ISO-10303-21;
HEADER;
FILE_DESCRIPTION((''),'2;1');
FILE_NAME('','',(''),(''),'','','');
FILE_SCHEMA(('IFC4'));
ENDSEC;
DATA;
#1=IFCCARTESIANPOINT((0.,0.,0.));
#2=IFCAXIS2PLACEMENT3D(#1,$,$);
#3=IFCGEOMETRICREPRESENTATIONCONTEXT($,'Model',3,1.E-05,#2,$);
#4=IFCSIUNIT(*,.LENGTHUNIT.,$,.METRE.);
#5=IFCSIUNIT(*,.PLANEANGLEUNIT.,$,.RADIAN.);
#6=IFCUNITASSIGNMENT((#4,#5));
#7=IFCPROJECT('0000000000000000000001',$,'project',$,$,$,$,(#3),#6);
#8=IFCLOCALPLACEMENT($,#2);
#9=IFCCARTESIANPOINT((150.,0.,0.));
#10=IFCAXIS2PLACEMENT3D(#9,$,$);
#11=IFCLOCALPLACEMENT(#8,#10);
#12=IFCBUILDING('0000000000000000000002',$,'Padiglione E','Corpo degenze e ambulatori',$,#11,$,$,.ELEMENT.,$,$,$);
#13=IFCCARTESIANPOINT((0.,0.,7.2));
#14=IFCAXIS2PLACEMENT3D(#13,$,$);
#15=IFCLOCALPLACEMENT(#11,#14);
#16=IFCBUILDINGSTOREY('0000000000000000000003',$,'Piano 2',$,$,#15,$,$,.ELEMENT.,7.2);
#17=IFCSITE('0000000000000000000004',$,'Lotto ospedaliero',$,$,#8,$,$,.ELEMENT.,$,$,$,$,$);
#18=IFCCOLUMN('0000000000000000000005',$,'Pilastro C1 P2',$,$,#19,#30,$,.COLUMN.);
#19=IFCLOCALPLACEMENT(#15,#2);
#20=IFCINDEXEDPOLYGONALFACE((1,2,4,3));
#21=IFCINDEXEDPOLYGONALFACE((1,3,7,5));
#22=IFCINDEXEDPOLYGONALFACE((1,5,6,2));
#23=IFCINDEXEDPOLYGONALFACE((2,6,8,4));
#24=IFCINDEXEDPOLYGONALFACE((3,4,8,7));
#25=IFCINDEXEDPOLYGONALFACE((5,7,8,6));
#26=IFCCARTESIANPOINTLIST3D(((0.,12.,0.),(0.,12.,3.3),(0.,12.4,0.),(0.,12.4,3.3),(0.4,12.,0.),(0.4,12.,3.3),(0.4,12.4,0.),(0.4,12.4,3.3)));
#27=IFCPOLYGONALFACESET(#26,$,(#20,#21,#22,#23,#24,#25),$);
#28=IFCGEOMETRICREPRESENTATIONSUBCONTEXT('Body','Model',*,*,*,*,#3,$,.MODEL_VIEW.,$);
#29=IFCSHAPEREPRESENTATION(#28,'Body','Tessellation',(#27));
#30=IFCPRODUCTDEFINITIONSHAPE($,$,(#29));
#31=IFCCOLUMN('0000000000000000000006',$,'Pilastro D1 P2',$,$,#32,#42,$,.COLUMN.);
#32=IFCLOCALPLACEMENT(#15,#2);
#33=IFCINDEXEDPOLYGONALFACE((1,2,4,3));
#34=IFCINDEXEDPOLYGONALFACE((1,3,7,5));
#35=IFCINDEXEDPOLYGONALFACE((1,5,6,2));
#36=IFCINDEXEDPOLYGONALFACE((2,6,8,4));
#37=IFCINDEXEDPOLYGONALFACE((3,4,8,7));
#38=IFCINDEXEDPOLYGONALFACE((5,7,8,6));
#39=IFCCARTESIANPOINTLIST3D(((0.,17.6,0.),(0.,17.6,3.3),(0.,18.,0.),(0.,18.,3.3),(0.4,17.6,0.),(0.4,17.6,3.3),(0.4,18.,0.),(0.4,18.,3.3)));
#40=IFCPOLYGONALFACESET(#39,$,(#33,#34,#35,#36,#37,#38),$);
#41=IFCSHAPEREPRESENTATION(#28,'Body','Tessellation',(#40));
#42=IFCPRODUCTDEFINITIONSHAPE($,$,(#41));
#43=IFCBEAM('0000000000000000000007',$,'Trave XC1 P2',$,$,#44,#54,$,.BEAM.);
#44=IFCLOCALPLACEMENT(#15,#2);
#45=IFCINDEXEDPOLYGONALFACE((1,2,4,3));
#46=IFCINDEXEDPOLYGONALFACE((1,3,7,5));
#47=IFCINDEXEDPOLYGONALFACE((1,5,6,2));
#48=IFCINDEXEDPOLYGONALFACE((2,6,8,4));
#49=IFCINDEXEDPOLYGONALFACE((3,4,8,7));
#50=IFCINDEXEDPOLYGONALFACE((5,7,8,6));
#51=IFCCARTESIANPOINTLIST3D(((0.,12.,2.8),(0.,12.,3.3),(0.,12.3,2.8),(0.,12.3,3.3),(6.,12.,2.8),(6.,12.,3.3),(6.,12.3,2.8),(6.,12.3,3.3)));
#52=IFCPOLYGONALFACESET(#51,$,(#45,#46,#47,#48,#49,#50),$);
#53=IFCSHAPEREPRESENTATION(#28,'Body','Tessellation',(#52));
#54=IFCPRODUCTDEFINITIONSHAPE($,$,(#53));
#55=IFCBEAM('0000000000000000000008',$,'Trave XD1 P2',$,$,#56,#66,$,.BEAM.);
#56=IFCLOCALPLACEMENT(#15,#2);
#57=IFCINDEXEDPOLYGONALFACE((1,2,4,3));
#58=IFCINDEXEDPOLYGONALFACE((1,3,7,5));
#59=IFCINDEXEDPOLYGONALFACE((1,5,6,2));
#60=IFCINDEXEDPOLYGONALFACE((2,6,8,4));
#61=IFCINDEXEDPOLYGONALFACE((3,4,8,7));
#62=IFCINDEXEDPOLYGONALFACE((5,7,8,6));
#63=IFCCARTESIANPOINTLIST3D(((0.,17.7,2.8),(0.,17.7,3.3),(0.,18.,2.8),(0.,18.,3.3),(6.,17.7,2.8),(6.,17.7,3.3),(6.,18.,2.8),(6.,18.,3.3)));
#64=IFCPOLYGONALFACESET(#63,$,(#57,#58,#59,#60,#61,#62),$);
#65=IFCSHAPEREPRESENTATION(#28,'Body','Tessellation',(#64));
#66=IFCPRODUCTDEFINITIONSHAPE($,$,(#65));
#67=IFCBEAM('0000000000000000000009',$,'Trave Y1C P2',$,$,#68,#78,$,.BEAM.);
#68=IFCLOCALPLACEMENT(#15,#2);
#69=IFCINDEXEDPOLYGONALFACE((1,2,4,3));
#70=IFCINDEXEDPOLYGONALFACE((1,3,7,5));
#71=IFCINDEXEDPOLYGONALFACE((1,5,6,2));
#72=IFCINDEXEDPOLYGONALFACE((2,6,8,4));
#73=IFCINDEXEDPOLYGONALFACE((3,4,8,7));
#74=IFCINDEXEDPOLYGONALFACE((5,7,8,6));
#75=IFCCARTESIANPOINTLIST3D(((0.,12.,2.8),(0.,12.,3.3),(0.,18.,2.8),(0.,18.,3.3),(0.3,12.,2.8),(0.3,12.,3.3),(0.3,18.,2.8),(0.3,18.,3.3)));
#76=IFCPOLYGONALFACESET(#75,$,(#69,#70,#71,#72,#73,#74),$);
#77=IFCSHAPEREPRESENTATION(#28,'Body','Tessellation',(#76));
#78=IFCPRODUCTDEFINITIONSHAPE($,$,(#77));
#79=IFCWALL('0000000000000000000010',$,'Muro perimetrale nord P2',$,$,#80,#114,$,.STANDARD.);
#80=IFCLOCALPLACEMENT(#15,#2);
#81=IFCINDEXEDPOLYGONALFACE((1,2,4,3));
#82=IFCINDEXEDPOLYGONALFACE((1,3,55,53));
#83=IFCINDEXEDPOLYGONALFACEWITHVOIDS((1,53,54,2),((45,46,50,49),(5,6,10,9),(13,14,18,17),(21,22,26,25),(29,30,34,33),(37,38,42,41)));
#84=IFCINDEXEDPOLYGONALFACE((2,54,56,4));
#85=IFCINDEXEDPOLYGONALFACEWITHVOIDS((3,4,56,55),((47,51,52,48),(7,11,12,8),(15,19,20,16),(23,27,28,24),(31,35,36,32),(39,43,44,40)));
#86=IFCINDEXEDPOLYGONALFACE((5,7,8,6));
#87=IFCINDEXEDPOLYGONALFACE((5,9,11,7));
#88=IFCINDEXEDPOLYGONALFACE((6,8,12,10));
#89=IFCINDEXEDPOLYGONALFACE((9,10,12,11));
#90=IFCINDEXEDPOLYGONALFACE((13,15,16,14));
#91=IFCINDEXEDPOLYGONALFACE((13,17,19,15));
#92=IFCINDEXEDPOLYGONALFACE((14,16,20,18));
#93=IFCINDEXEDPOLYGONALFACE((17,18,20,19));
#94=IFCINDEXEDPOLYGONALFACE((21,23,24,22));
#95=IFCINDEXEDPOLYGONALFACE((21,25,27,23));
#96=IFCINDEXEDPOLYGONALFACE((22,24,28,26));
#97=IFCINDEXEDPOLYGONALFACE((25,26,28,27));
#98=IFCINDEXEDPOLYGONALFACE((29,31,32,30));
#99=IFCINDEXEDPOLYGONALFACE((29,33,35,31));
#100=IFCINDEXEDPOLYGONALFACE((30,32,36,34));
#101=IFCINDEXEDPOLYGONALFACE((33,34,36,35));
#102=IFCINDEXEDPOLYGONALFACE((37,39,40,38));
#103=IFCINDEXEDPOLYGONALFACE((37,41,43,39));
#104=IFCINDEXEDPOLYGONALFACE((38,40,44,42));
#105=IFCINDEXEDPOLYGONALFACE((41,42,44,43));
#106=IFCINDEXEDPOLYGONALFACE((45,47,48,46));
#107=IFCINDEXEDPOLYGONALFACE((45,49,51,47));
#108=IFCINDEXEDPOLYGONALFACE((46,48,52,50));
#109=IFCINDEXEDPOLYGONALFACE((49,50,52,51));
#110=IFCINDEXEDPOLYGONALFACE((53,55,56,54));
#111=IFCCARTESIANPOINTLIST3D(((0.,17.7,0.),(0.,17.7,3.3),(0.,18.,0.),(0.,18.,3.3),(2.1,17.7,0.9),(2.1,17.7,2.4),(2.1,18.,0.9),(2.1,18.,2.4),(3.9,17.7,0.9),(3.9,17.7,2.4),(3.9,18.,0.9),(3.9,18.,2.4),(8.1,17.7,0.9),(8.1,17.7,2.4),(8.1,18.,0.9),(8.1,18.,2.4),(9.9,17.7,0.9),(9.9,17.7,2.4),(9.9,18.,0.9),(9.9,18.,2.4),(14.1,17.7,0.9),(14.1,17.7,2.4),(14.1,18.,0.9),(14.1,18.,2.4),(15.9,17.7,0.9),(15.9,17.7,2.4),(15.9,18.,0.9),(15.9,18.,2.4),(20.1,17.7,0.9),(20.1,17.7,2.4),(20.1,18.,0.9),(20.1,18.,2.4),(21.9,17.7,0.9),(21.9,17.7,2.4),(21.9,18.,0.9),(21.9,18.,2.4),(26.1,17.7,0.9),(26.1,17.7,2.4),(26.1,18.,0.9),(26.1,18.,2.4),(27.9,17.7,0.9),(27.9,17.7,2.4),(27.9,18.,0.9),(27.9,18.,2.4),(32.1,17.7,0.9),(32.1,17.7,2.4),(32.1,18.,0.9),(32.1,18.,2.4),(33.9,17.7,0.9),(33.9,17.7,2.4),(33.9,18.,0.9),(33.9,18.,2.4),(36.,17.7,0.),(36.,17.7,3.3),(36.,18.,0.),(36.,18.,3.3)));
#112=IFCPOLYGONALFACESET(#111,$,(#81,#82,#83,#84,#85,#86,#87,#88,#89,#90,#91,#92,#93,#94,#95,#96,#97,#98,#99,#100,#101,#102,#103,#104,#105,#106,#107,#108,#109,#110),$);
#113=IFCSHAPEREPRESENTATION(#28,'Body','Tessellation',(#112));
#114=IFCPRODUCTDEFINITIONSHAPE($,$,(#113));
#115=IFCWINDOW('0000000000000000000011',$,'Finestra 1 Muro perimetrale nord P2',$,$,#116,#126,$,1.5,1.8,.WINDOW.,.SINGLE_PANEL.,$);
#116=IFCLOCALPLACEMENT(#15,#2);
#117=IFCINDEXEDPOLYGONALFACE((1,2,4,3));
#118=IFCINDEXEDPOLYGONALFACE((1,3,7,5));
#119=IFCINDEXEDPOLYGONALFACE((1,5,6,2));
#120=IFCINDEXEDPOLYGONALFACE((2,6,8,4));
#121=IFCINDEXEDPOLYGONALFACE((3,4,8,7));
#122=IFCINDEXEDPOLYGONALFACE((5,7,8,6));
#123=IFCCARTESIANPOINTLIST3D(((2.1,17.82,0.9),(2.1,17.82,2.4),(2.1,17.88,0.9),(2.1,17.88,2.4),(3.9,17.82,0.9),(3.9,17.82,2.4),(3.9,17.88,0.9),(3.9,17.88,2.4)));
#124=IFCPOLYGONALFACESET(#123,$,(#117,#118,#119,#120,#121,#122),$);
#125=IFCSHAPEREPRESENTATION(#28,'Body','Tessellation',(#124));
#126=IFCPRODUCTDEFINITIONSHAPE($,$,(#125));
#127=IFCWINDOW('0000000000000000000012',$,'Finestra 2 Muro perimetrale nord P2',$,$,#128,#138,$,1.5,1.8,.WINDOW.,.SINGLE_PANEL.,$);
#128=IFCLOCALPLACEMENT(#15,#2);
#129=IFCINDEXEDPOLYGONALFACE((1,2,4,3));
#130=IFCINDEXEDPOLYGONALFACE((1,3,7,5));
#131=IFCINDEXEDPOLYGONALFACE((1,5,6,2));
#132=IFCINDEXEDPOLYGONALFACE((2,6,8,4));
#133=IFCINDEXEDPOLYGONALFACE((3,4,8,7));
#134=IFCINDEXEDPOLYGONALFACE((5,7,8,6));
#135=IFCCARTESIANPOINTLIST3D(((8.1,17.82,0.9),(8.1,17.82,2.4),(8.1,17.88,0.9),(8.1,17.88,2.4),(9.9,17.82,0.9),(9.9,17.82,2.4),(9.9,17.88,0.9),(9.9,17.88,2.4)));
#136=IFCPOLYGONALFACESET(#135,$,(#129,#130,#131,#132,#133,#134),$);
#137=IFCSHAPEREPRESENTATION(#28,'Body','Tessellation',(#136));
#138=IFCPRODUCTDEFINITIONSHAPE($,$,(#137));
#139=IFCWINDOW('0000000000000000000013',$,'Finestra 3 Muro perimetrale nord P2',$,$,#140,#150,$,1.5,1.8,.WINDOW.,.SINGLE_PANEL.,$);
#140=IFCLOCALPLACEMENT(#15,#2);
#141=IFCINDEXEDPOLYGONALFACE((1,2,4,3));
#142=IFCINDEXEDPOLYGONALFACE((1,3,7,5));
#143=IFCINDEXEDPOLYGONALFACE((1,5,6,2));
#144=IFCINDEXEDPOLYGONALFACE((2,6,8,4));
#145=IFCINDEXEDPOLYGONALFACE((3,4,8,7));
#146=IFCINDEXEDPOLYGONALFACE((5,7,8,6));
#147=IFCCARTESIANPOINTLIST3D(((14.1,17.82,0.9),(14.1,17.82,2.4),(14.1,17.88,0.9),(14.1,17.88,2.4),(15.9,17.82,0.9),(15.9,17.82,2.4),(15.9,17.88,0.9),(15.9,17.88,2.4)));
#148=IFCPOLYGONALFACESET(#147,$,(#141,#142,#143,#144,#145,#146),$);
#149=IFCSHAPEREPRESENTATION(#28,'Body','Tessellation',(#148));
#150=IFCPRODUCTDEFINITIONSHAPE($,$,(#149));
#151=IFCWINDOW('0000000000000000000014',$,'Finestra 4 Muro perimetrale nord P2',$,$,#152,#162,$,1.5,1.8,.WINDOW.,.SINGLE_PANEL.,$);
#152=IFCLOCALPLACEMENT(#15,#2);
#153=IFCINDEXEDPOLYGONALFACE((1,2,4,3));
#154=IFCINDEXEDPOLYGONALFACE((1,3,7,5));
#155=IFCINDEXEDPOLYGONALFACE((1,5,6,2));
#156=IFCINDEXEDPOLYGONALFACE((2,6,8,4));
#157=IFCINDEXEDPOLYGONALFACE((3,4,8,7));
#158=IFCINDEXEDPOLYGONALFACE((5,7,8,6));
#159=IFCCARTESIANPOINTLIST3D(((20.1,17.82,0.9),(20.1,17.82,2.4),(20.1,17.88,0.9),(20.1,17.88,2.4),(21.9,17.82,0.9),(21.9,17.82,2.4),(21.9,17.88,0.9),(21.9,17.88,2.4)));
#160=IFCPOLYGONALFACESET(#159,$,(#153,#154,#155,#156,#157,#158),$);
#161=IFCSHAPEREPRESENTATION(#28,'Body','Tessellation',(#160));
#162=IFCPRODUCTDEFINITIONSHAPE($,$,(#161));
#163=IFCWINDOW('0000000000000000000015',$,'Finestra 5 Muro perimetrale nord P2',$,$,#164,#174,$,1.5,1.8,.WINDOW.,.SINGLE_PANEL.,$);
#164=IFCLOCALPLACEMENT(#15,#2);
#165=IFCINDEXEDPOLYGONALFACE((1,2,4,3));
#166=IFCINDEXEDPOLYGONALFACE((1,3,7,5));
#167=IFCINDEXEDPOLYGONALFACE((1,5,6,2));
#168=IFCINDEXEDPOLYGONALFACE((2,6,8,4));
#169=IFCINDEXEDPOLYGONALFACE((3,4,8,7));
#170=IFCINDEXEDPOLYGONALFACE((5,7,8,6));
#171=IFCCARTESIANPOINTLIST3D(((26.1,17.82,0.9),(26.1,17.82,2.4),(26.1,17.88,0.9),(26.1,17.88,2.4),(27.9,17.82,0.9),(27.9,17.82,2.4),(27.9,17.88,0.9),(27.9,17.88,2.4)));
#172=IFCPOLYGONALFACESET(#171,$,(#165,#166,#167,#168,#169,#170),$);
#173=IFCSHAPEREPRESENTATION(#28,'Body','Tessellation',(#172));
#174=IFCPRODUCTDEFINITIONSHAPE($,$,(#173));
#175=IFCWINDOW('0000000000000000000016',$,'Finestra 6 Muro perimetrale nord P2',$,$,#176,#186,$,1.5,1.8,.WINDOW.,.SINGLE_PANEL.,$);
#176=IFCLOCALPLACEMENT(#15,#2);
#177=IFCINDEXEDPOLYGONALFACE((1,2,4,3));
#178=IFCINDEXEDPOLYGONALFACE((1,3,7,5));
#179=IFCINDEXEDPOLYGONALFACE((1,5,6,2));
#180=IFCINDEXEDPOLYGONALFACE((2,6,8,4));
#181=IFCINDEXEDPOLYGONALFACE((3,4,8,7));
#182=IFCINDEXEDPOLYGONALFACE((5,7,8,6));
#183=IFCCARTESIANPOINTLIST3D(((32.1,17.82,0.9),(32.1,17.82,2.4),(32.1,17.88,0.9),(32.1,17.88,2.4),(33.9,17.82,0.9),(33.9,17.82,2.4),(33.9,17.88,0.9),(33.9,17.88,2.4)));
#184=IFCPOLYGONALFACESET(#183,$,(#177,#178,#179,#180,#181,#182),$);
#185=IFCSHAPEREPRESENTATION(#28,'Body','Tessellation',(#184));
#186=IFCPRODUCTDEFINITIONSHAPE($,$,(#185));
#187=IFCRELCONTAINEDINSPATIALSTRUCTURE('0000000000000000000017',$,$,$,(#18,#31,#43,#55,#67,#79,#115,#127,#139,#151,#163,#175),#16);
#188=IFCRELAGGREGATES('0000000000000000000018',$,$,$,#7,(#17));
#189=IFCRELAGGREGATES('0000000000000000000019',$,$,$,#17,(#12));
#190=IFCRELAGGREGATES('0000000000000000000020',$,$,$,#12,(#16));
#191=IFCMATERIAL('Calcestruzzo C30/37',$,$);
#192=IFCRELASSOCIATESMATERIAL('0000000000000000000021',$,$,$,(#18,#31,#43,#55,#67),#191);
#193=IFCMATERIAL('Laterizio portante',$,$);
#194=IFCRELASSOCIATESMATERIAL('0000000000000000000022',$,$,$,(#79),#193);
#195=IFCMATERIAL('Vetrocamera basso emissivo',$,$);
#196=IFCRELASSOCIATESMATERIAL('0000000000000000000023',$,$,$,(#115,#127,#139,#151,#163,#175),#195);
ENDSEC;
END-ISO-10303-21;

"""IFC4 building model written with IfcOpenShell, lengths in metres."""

from ifc_helpers import new_model, si_unit, frame, frame_2d, origin, place, context, subcontext, project, spatial, rectangle, extrude, material, element, fill, save


model = new_model("IFC4")

# Units and contexts
model_context = context("Model", 3, precision=1e-05, world=origin())
body_context = subcontext(model_context, "Body", "Model", "MODEL_VIEW")
ifc_project = project(units=[si_unit("LENGTHUNIT", "METRE"), si_unit("PLANEANGLEUNIT", "RADIAN")], contexts=[model_context])

# Site, building, storey
site_placement = place(None, origin())
site = spatial("IfcSite", under=ifc_project, at=site_placement, Name="Lotto ospedaliero", CompositionType="ELEMENT")
building_placement = place(site_placement, frame((150.0, 0.0, 0.0)))
building = spatial("IfcBuilding", under=site, at=building_placement, Name="Padiglione E", Description="Corpo degenze e ambulatori", CompositionType="ELEMENT")
storey_placement = place(building_placement, frame((0.0, 0.0, 7.2)))
storey = spatial("IfcBuildingStorey", under=building, at=storey_placement, Name="Piano 2", CompositionType="ELEMENT", Elevation=7.2)

# Columns
ifc_material_1 = material(Name="Calcestruzzo C30/37")
for number, where, name in (
    (1, (0.0, 12.0, 0.0), "Pilastro C1 P2"),
    (2, (0.0, 17.6, 0.0), "Pilastro D1 P2"),
):
    element("IfcColumn", number, at=place(storey_placement, frame(where)), inside=storey, material=ifc_material_1, Name=name, PredefinedType="COLUMN", context=body_context, shape_type="SweptSolid", body=[
        extrude(rectangle(XDim=0.4, YDim=0.4, at=frame_2d((0.2, 0.2))), origin(), (0.0, 0.0, 1.0), 3.3),
    ])

# Beams
for number, where, name in (
    (3, (0.0, 12.0, 2.8), "Trave XC1 P2"),
    (4, (0.0, 17.7, 2.8), "Trave XD1 P2"),
):
    element("IfcBeam", number, at=place(storey_placement, frame(where)), inside=storey, material=ifc_material_1, Name=name, PredefinedType="BEAM", context=body_context, shape_type="SweptSolid", body=[
        extrude(rectangle(XDim=6.0, YDim=0.3, at=frame_2d((3.0, 0.15))), origin(), (0.0, 0.0, 1.0), 0.5),
    ])
beam_placement = place(storey_placement, frame((0.0, 12.0, 2.8)))
element("IfcBeam", 5, at=beam_placement, inside=storey, material=ifc_material_1, Name="Trave Y1C P2", PredefinedType="BEAM", context=body_context, shape_type="SweptSolid", body=[
    extrude(rectangle(XDim=0.3, YDim=6.0, at=frame_2d((0.15, 3.0))), origin(), (0.0, 0.0, 1.0), 0.5),
])

# Wall, openings, windows
ifc_material_2 = material(Name="Laterizio portante")
wall_placement = place(storey_placement, frame((0.0, 17.7, 0.0)))
wall = element("IfcWall", 6, at=wall_placement, inside=storey, material=ifc_material_2, Name="Muro perimetrale nord P2", PredefinedType="STANDARD", context=body_context, shape_type="SweptSolid", body=[
    extrude(rectangle(XDim=36.0, YDim=0.3, at=frame_2d((18.0, 0.15))), origin(), (0.0, 0.0, 1.0), 3.3),
])
opening_1_placement = place(wall_placement, frame((2.1, -0.1, 0.9)))
opening_1 = element("IfcOpeningElement", 7, at=opening_1_placement, cuts=wall, PredefinedType="OPENING", context=body_context, shape_type="SweptSolid", body=[
    extrude(rectangle(XDim=1.8, YDim=0.5, at=frame_2d((0.9, 0.25))), origin(), (0.0, 0.0, 1.0), 1.5),
])
opening_2_placement = place(wall_placement, frame((8.1, -0.1, 0.9)))
opening_2 = element("IfcOpeningElement", 8, at=opening_2_placement, cuts=wall, PredefinedType="OPENING", context=body_context, shape_type="SweptSolid", body=[
    extrude(rectangle(XDim=1.8, YDim=0.5, at=frame_2d((0.9, 0.25))), origin(), (0.0, 0.0, 1.0), 1.5),
])
opening_3_placement = place(wall_placement, frame((14.1, -0.1, 0.9)))
opening_3 = element("IfcOpeningElement", 9, at=opening_3_placement, cuts=wall, PredefinedType="OPENING", context=body_context, shape_type="SweptSolid", body=[
    extrude(rectangle(XDim=1.8, YDim=0.5, at=frame_2d((0.9, 0.25))), origin(), (0.0, 0.0, 1.0), 1.5),
])
opening_4_placement = place(wall_placement, frame((20.1, -0.1, 0.9)))
opening_4 = element("IfcOpeningElement", 10, at=opening_4_placement, cuts=wall, PredefinedType="OPENING", context=body_context, shape_type="SweptSolid", body=[
    extrude(rectangle(XDim=1.8, YDim=0.5, at=frame_2d((0.9, 0.25))), origin(), (0.0, 0.0, 1.0), 1.5),
])
opening_5_placement = place(wall_placement, frame((26.1, -0.1, 0.9)))
opening_5 = element("IfcOpeningElement", 11, at=opening_5_placement, cuts=wall, PredefinedType="OPENING", context=body_context, shape_type="SweptSolid", body=[
    extrude(rectangle(XDim=1.8, YDim=0.5, at=frame_2d((0.9, 0.25))), origin(), (0.0, 0.0, 1.0), 1.5),
])
opening_6_placement = place(wall_placement, frame((32.1, -0.1, 0.9)))
opening_6 = element("IfcOpeningElement", 12, at=opening_6_placement, cuts=wall, PredefinedType="OPENING", context=body_context, shape_type="SweptSolid", body=[
    extrude(rectangle(XDim=1.8, YDim=0.5, at=frame_2d((0.9, 0.25))), origin(), (0.0, 0.0, 1.0), 1.5),
])
ifc_material_3 = material(Name="Vetrocamera basso emissivo")
window_1_placement = place(wall_placement, frame((2.1, 0.12, 0.9)))
window_1 = element("IfcWindow", 13, at=window_1_placement, inside=storey, material=ifc_material_3, Name="Finestra 1 Muro perimetrale nord P2", OverallHeight=1.5, OverallWidth=1.8, PartitioningType="SINGLE_PANEL", PredefinedType="WINDOW", context=body_context, shape_type="SweptSolid", body=[
    extrude(rectangle(XDim=1.8, YDim=0.06, at=frame_2d((0.9, 0.03))), origin(), (0.0, 0.0, 1.0), 1.5),
])
fill(opening_1, window_1)
window_2_placement = place(wall_placement, frame((8.1, 0.12, 0.9)))
window_2 = element("IfcWindow", 14, at=window_2_placement, inside=storey, material=ifc_material_3, Name="Finestra 2 Muro perimetrale nord P2", OverallHeight=1.5, OverallWidth=1.8, PartitioningType="SINGLE_PANEL", PredefinedType="WINDOW", context=body_context, shape_type="SweptSolid", body=[
    extrude(rectangle(XDim=1.8, YDim=0.06, at=frame_2d((0.9, 0.03))), origin(), (0.0, 0.0, 1.0), 1.5),
])
fill(opening_2, window_2)
window_3_placement = place(wall_placement, frame((14.1, 0.12, 0.9)))
window_3 = element("IfcWindow", 15, at=window_3_placement, inside=storey, material=ifc_material_3, Name="Finestra 3 Muro perimetrale nord P2", OverallHeight=1.5, OverallWidth=1.8, PartitioningType="SINGLE_PANEL", PredefinedType="WINDOW", context=body_context, shape_type="SweptSolid", body=[
    extrude(rectangle(XDim=1.8, YDim=0.06, at=frame_2d((0.9, 0.03))), origin(), (0.0, 0.0, 1.0), 1.5),
])
fill(opening_3, window_3)
window_4_placement = place(wall_placement, frame((20.1, 0.12, 0.9)))
window_4 = element("IfcWindow", 16, at=window_4_placement, inside=storey, material=ifc_material_3, Name="Finestra 4 Muro perimetrale nord P2", OverallHeight=1.5, OverallWidth=1.8, PartitioningType="SINGLE_PANEL", PredefinedType="WINDOW", context=body_context, shape_type="SweptSolid", body=[
    extrude(rectangle(XDim=1.8, YDim=0.06, at=frame_2d((0.9, 0.03))), origin(), (0.0, 0.0, 1.0), 1.5),
])
fill(opening_4, window_4)
window_5_placement = place(wall_placement, frame((26.1, 0.12, 0.9)))
window_5 = element("IfcWindow", 17, at=window_5_placement, inside=storey, material=ifc_material_3, Name="Finestra 5 Muro perimetrale nord P2", OverallHeight=1.5, OverallWidth=1.8, PartitioningType="SINGLE_PANEL", PredefinedType="WINDOW", context=body_context, shape_type="SweptSolid", body=[
    extrude(rectangle(XDim=1.8, YDim=0.06, at=frame_2d((0.9, 0.03))), origin(), (0.0, 0.0, 1.0), 1.5),
])
fill(opening_5, window_5)
window_6_placement = place(wall_placement, frame((32.1, 0.12, 0.9)))
window_6 = element("IfcWindow", 18, at=window_6_placement, inside=storey, material=ifc_material_3, Name="Finestra 6 Muro perimetrale nord P2", OverallHeight=1.5, OverallWidth=1.8, PartitioningType="SINGLE_PANEL", PredefinedType="WINDOW", context=body_context, shape_type="SweptSolid", body=[
    extrude(rectangle(XDim=1.8, YDim=0.06, at=frame_2d((0.9, 0.03))), origin(), (0.0, 0.0, 1.0), 1.5),
])
fill(opening_6, window_6)

save(model, "model.ifc")
